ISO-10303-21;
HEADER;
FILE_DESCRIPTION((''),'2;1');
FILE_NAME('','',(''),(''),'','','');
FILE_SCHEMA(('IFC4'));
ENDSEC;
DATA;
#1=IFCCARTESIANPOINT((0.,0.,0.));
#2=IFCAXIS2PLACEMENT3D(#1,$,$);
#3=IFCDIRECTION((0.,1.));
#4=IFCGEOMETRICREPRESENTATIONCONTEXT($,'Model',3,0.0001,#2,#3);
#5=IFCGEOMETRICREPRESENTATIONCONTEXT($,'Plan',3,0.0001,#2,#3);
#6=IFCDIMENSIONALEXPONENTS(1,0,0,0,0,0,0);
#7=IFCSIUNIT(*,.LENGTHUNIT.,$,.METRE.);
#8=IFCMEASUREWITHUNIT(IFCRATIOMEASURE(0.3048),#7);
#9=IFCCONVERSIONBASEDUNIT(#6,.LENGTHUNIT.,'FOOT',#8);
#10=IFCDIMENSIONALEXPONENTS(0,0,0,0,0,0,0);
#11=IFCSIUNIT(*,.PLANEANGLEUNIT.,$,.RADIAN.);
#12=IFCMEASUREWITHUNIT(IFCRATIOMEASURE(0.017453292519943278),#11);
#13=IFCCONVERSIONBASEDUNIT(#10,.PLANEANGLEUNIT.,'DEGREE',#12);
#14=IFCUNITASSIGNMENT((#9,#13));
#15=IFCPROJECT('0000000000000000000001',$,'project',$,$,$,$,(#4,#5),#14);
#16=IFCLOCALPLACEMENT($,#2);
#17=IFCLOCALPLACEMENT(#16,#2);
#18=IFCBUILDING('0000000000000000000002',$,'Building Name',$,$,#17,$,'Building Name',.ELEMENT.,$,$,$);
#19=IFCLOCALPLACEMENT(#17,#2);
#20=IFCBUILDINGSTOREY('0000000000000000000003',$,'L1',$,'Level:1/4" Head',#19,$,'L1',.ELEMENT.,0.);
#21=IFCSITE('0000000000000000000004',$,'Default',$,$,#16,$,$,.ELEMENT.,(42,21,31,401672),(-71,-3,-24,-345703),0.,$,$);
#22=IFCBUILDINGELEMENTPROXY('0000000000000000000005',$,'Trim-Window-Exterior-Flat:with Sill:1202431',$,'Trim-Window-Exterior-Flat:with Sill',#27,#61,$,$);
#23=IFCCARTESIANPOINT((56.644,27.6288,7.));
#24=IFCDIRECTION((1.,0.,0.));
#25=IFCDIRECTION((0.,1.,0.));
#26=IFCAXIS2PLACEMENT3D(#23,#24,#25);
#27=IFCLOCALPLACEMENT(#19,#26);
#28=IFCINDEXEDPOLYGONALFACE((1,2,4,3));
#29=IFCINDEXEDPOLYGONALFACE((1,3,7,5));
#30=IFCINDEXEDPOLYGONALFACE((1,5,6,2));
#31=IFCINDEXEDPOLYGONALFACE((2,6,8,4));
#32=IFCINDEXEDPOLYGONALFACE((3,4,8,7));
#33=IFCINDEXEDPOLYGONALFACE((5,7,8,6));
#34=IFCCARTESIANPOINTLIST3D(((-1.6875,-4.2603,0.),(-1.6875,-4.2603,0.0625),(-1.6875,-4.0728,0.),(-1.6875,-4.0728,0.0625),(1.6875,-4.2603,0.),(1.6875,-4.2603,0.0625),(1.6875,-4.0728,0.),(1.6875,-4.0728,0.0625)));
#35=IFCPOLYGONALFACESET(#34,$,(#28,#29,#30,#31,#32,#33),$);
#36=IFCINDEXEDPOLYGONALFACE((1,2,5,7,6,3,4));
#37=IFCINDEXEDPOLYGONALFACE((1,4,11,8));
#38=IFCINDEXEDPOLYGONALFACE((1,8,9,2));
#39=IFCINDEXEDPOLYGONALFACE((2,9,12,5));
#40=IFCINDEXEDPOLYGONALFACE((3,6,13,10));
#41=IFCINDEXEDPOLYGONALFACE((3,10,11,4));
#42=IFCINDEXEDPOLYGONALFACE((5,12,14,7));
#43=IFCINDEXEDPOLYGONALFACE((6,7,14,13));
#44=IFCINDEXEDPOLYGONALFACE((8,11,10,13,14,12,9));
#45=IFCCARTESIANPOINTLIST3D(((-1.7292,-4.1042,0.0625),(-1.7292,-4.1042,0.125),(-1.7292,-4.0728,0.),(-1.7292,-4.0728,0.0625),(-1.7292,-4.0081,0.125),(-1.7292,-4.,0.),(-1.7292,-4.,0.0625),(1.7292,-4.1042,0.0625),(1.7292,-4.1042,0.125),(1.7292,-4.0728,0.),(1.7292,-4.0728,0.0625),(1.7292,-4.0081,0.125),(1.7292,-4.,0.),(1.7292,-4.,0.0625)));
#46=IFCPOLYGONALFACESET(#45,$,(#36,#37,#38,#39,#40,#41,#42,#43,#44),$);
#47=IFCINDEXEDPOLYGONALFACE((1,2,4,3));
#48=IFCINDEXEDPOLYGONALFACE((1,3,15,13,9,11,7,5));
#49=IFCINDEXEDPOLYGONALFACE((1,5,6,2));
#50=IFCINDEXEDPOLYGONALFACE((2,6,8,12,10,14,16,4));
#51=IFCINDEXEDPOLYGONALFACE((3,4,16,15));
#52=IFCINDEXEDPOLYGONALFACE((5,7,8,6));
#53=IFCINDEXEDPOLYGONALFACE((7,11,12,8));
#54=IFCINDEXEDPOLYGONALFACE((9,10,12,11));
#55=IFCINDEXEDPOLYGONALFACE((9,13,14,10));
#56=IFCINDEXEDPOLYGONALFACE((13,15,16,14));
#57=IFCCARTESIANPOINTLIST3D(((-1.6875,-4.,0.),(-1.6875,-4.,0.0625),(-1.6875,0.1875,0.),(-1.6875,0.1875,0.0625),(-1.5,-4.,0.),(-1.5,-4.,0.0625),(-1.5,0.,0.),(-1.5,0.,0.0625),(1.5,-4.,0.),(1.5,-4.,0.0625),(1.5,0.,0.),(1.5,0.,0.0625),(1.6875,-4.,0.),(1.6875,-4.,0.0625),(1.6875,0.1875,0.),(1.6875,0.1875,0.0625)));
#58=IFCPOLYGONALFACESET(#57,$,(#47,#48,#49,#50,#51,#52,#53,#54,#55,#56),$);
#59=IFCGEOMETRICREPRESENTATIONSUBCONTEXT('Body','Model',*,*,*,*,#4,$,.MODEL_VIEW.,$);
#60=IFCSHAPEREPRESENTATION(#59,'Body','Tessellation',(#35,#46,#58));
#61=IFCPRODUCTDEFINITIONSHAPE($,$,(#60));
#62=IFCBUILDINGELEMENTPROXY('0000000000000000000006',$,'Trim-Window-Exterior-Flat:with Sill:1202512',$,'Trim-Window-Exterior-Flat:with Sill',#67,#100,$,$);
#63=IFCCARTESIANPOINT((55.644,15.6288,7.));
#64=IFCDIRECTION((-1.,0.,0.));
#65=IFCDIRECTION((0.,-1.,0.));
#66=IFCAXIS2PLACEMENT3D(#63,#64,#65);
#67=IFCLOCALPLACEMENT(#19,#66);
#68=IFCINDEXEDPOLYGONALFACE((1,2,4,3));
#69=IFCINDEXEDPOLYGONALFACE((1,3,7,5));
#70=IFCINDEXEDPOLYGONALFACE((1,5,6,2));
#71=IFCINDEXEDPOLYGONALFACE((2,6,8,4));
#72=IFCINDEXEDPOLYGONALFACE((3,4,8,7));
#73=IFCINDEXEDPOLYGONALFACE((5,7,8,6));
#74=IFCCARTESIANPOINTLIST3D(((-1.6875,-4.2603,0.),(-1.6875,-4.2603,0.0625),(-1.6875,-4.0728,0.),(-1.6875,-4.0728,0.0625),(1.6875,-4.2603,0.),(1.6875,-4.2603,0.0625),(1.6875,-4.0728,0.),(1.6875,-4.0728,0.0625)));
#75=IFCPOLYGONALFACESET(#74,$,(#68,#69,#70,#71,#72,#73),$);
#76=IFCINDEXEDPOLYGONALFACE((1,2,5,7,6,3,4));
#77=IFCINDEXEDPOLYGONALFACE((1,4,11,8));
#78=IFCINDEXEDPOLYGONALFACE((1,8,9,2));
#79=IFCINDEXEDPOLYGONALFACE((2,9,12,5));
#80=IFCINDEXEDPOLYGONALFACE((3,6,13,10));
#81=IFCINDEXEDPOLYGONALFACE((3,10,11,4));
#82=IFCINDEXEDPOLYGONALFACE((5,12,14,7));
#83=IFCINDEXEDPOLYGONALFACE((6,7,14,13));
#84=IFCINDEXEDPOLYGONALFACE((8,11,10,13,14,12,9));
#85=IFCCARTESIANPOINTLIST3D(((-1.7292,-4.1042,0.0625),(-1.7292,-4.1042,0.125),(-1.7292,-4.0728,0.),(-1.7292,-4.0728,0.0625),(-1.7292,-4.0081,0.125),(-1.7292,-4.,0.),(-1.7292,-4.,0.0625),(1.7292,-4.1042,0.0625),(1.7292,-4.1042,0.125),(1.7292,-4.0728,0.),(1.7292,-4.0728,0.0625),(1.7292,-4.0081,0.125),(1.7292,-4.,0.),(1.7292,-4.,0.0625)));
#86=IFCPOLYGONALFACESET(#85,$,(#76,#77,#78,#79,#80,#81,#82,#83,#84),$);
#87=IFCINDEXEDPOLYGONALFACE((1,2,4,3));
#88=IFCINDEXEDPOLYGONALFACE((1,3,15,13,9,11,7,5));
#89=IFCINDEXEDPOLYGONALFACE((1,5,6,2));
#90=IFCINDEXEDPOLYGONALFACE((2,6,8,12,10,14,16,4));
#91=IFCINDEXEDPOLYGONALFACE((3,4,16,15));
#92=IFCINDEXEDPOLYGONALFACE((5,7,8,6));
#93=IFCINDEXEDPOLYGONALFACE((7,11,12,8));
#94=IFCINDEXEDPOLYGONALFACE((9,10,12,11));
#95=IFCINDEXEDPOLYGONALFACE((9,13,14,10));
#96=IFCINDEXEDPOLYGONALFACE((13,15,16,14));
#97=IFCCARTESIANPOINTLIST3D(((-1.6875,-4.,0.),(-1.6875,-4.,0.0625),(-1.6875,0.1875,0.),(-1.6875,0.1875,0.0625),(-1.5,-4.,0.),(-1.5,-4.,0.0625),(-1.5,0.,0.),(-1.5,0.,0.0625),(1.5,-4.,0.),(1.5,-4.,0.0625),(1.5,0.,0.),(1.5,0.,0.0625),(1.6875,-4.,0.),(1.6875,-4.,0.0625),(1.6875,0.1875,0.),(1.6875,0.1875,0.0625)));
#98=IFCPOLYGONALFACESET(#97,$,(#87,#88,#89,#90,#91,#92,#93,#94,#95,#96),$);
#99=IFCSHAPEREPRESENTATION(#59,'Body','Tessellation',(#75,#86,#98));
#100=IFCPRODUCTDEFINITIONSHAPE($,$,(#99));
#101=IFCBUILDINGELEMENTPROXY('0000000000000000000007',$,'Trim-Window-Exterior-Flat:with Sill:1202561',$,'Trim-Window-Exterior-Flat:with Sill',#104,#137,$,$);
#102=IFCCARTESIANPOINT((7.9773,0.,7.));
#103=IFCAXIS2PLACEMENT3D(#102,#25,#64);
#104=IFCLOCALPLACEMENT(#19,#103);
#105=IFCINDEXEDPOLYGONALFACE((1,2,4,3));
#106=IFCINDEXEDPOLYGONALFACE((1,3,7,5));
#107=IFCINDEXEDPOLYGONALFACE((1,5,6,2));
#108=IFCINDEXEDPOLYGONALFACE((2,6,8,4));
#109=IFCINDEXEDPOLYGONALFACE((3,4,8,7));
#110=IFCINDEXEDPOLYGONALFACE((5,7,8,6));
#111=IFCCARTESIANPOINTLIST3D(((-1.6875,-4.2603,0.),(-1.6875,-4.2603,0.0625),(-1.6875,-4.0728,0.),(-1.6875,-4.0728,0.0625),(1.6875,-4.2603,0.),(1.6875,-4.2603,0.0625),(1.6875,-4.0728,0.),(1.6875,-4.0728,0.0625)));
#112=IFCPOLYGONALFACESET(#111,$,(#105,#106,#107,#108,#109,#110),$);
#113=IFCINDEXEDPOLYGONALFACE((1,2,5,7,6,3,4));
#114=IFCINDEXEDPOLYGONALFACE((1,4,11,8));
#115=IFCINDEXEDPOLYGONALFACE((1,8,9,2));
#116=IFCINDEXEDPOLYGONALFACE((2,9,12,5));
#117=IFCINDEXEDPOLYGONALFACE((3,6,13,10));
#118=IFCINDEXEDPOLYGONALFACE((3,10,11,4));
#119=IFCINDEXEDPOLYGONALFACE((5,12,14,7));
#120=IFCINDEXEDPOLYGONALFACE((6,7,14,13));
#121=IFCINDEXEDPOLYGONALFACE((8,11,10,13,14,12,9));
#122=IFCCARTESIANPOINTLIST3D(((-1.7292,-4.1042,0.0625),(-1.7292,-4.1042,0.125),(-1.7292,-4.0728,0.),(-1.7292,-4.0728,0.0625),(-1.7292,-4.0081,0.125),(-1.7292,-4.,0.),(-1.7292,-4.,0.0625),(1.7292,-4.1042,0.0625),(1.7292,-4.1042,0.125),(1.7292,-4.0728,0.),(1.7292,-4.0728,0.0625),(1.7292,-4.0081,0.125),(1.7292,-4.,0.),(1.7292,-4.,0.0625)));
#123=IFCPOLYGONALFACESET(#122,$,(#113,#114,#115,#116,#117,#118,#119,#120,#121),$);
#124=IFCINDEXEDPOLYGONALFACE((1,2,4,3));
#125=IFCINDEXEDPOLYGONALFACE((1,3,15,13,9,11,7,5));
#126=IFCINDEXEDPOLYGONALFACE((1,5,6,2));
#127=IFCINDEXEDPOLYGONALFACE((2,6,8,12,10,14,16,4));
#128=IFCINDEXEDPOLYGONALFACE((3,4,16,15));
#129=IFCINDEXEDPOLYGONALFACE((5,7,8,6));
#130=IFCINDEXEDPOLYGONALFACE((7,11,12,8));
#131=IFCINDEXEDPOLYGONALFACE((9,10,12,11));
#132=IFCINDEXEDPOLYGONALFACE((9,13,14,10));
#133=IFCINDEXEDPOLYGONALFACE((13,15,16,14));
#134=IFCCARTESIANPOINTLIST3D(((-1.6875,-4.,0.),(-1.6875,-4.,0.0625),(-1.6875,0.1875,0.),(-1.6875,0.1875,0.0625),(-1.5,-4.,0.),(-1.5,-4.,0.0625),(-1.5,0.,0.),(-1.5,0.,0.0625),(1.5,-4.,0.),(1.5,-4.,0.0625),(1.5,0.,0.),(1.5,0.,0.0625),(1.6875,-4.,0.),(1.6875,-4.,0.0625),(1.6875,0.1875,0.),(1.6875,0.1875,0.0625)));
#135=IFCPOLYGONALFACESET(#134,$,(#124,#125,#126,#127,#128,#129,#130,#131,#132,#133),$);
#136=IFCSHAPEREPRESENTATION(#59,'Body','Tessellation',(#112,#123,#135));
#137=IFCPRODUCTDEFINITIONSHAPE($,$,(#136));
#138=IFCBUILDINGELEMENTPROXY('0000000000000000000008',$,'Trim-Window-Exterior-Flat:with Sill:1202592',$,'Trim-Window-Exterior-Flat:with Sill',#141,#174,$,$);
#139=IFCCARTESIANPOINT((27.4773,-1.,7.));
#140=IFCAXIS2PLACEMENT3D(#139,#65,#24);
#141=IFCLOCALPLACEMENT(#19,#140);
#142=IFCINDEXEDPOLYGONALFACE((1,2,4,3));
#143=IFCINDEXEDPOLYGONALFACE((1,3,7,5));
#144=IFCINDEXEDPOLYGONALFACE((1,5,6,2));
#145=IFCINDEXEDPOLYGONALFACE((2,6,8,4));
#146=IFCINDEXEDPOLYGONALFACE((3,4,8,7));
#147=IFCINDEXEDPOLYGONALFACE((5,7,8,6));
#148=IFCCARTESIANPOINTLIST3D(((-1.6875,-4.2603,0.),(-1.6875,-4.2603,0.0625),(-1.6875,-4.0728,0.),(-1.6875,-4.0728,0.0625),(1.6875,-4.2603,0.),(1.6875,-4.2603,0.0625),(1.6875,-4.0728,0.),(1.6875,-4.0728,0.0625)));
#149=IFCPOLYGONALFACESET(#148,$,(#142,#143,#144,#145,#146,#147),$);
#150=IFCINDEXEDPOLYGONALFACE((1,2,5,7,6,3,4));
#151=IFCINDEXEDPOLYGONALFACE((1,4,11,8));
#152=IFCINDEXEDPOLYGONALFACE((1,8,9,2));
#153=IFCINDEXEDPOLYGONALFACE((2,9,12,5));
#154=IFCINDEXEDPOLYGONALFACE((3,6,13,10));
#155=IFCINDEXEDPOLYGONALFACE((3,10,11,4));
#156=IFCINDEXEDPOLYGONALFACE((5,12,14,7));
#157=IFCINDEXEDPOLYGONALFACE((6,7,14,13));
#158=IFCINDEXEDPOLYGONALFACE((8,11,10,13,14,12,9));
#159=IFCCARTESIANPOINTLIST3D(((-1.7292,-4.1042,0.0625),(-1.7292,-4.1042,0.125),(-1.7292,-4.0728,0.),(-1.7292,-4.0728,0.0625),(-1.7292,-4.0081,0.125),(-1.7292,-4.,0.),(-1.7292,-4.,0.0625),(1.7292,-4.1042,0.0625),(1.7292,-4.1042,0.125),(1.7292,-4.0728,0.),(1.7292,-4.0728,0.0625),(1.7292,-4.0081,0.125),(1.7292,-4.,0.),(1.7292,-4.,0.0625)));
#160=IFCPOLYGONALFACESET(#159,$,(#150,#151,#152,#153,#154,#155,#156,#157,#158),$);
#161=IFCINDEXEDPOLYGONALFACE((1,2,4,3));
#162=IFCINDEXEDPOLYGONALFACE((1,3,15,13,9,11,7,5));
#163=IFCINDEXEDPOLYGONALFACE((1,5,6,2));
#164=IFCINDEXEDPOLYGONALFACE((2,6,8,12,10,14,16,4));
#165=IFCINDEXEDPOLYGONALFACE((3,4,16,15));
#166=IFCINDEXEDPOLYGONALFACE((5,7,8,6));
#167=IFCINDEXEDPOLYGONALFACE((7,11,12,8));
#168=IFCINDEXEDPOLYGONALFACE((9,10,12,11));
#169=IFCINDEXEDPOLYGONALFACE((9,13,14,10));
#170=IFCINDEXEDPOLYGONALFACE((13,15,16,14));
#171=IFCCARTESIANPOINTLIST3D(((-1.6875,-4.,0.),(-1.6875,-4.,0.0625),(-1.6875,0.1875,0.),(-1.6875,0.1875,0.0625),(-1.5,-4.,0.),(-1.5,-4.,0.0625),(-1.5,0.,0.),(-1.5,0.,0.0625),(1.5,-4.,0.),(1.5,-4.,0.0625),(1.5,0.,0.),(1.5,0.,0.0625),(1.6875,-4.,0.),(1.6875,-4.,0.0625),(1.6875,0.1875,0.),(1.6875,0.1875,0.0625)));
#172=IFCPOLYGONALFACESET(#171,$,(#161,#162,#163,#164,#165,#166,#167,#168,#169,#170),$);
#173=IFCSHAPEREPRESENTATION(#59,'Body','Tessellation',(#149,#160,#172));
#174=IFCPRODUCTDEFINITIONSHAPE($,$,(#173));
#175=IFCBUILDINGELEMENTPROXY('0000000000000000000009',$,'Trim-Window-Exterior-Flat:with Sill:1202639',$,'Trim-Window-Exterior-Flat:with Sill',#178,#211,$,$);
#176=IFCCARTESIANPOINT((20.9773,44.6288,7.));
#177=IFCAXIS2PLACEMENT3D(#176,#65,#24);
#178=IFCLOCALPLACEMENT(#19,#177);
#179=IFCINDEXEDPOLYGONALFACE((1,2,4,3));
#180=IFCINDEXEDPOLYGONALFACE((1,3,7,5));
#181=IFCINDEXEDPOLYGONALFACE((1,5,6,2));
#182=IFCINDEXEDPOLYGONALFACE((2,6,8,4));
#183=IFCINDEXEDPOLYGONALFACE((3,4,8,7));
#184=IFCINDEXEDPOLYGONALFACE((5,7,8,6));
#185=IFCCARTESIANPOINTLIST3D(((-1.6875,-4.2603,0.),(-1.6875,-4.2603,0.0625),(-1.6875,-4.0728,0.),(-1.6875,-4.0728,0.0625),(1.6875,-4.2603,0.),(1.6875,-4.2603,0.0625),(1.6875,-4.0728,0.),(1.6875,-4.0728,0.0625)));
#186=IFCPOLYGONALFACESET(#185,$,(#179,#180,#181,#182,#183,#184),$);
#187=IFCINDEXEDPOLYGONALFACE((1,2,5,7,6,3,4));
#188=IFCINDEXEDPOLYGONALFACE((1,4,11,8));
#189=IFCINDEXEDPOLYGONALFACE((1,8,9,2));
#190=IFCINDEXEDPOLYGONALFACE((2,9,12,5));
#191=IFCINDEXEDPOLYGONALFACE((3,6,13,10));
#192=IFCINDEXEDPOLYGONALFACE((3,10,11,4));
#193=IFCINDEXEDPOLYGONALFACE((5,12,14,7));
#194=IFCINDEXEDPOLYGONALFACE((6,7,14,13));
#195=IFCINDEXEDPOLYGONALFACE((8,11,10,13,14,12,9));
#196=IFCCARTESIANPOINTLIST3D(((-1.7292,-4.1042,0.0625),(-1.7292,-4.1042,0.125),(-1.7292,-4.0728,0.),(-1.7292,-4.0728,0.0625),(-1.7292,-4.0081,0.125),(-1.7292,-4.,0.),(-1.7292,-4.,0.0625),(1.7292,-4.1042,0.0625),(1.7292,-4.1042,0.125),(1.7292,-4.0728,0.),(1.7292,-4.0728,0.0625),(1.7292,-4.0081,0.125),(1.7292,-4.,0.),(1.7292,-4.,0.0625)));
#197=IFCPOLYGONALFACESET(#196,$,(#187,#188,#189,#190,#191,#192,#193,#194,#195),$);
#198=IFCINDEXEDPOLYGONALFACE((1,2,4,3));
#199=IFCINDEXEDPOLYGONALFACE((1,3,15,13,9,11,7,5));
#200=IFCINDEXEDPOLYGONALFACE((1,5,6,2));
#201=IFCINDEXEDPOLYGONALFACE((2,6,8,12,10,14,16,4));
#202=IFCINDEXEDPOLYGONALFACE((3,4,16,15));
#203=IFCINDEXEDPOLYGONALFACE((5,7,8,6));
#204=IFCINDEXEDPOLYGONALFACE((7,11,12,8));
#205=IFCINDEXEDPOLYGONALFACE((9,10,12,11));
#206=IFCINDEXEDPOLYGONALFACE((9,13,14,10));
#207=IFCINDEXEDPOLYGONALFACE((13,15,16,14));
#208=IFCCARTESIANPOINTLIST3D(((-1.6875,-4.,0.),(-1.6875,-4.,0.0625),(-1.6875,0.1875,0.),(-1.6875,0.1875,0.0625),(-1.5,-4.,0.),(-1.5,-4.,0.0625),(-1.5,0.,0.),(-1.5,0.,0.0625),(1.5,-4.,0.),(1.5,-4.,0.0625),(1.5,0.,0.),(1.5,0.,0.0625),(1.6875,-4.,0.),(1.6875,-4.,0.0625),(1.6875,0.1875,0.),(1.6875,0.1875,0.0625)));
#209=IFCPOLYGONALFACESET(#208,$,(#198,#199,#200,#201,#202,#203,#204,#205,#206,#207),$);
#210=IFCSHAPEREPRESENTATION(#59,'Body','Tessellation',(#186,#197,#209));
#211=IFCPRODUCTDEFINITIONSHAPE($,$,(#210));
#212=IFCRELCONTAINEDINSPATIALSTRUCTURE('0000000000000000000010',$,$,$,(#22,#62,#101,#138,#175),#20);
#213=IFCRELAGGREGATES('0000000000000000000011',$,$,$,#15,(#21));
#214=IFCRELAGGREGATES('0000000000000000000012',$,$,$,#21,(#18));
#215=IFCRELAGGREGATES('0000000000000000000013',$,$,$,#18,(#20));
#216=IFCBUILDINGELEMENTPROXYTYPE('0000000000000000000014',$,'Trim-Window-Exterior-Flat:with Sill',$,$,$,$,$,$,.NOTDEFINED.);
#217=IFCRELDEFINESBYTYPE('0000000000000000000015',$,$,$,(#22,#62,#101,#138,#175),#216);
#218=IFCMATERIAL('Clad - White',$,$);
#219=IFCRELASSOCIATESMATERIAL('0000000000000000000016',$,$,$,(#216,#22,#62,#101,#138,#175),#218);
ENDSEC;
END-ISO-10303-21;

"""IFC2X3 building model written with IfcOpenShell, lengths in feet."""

from ifc_helpers import new_model, entity, si_unit, converted_unit, direction, frame, frame_2d, origin, place, context, subcontext, project, spatial, polyline, rectangle, outline, extrude, source, transform, mapped, material, type_object, type_shapes, element, save


model = new_model("IFC2X3")

# Units and contexts
model_context = context("Model", 3, precision=0.0001, world=origin(), true_north=direction((0.0, 1.0)))
plan_context = context("Plan", 3, precision=0.0001, world=origin(), true_north=direction((0.0, 1.0)))
body_context = subcontext(model_context, "Body", "Model", "MODEL_VIEW")
ifc_project = project(units=[converted_unit("LENGTHUNIT", "FOOT", entity("IfcRatioMeasure", 0.3048), si_unit("LENGTHUNIT", "METRE"), dimensions=[1, 0, 0, 0, 0, 0, 0]), converted_unit("PLANEANGLEUNIT", "DEGREE", entity("IfcRatioMeasure", 0.017453292519943278), si_unit("PLANEANGLEUNIT", "RADIAN"), dimensions=[0, 0, 0, 0, 0, 0, 0])], contexts=[model_context, plan_context])

# Site, building, storey
site_placement = place(None, origin())
site = spatial("IfcSite", under=ifc_project, at=site_placement, Name="Default", CompositionType="ELEMENT", RefLatitude=(42, 21, 31, 401672), RefLongitude=(-71, -3, -24, -345703), RefElevation=0.0)
building_placement = place(site_placement, origin())
building = spatial("IfcBuilding", under=site, at=building_placement, Name="Building Name", LongName="Building Name", CompositionType="ELEMENT")
storey_placement = place(building_placement, origin())
storey = spatial("IfcBuildingStorey", under=building, at=storey_placement, Name="L1", ObjectType="Level:1/4\" Head", LongName="L1", CompositionType="ELEMENT", Elevation=0.0)

# Building element proxies
ifc_material_1 = material(Name="Clad - White")
building_element_proxy_type_1 = type_object("IfcBuildingElementProxyType", Name="Trim-Window-Exterior-Flat:with Sill", PredefinedType="NOTDEFINED", material=ifc_material_1)
shared_shape_1 = source(origin(), body_context, "Body", "SweptSolid", [
    extrude(rectangle(XDim=3.375, YDim=0.1875, at=frame_2d((0.0, 0.0), x_axis=(1.0, 0.0))), frame((0.0, -4.1665, 0.0), z_axis=(0.0, 0.0, 1.0), x_axis=(-1.0, 0.0, 0.0)), (0.0, 0.0, 1.0), 0.0625),
    extrude(outline(polyline([(-0.0625, -0.0525), (0.0, -0.0525), (0.0, -0.0211), (0.0625, -0.0211), (0.0625, 0.0517), (0.0, 0.0517), (-0.0625, 0.0436), (-0.0625, -0.0525)])), frame((-1.7292, -4.0517, 0.0625), z_axis=(1.0, 0.0, 0.0), x_axis=(0.0, 0.0, -1.0)), (0.0, 0.0, 1.0), 3.4583),
    extrude(outline(polyline([(-2.1406, -1.6875), (2.0469, -1.6875), (2.0469, -1.5), (-1.9531, -1.5), (-1.9531, 1.5), (2.0469, 1.5), (2.0469, 1.6875), (-2.1406, 1.6875), (-2.1406, -1.6875)])), frame((0.0, -1.9531, 0.0), z_axis=(0.0, 0.0, 1.0), x_axis=(0.0, -1.0, 0.0)), (0.0, 0.0, 1.0), 0.0625),
])
type_shapes(building_element_proxy_type_1, [shared_shape_1])
for number, where, z_axis, x_axis, name in (
    (1, (56.644, 27.6288, 7.0), (1.0, 0.0, 0.0), (0.0, 1.0, 0.0), "Trim-Window-Exterior-Flat:with Sill:1202431"),
    (2, (55.644, 15.6288, 7.0), (-1.0, 0.0, 0.0), (0.0, -1.0, 0.0), "Trim-Window-Exterior-Flat:with Sill:1202512"),
    (3, (7.9773, 0.0, 7.0), (0.0, 1.0, 0.0), (-1.0, 0.0, 0.0), "Trim-Window-Exterior-Flat:with Sill:1202561"),
    (4, (27.4773, -1.0, 7.0), (0.0, -1.0, 0.0), (1.0, 0.0, 0.0), "Trim-Window-Exterior-Flat:with Sill:1202592"),
    (5, (20.9773, 44.6288, 7.0), (0.0, -1.0, 0.0), (1.0, 0.0, 0.0), "Trim-Window-Exterior-Flat:with Sill:1202639"),
):
    element("IfcBuildingElementProxy", number, at=place(storey_placement, frame(where, z_axis=z_axis, x_axis=x_axis)), inside=storey, type_object=building_element_proxy_type_1, material=ifc_material_1, Name=name, ObjectType="Trim-Window-Exterior-Flat:with Sill", context=body_context, shape_type="MappedRepresentation", body=[
        mapped(shared_shape_1, transform((0.0, 0.0, 0.0), scale=1.0)),
    ])

save(model, "model.ifc")
